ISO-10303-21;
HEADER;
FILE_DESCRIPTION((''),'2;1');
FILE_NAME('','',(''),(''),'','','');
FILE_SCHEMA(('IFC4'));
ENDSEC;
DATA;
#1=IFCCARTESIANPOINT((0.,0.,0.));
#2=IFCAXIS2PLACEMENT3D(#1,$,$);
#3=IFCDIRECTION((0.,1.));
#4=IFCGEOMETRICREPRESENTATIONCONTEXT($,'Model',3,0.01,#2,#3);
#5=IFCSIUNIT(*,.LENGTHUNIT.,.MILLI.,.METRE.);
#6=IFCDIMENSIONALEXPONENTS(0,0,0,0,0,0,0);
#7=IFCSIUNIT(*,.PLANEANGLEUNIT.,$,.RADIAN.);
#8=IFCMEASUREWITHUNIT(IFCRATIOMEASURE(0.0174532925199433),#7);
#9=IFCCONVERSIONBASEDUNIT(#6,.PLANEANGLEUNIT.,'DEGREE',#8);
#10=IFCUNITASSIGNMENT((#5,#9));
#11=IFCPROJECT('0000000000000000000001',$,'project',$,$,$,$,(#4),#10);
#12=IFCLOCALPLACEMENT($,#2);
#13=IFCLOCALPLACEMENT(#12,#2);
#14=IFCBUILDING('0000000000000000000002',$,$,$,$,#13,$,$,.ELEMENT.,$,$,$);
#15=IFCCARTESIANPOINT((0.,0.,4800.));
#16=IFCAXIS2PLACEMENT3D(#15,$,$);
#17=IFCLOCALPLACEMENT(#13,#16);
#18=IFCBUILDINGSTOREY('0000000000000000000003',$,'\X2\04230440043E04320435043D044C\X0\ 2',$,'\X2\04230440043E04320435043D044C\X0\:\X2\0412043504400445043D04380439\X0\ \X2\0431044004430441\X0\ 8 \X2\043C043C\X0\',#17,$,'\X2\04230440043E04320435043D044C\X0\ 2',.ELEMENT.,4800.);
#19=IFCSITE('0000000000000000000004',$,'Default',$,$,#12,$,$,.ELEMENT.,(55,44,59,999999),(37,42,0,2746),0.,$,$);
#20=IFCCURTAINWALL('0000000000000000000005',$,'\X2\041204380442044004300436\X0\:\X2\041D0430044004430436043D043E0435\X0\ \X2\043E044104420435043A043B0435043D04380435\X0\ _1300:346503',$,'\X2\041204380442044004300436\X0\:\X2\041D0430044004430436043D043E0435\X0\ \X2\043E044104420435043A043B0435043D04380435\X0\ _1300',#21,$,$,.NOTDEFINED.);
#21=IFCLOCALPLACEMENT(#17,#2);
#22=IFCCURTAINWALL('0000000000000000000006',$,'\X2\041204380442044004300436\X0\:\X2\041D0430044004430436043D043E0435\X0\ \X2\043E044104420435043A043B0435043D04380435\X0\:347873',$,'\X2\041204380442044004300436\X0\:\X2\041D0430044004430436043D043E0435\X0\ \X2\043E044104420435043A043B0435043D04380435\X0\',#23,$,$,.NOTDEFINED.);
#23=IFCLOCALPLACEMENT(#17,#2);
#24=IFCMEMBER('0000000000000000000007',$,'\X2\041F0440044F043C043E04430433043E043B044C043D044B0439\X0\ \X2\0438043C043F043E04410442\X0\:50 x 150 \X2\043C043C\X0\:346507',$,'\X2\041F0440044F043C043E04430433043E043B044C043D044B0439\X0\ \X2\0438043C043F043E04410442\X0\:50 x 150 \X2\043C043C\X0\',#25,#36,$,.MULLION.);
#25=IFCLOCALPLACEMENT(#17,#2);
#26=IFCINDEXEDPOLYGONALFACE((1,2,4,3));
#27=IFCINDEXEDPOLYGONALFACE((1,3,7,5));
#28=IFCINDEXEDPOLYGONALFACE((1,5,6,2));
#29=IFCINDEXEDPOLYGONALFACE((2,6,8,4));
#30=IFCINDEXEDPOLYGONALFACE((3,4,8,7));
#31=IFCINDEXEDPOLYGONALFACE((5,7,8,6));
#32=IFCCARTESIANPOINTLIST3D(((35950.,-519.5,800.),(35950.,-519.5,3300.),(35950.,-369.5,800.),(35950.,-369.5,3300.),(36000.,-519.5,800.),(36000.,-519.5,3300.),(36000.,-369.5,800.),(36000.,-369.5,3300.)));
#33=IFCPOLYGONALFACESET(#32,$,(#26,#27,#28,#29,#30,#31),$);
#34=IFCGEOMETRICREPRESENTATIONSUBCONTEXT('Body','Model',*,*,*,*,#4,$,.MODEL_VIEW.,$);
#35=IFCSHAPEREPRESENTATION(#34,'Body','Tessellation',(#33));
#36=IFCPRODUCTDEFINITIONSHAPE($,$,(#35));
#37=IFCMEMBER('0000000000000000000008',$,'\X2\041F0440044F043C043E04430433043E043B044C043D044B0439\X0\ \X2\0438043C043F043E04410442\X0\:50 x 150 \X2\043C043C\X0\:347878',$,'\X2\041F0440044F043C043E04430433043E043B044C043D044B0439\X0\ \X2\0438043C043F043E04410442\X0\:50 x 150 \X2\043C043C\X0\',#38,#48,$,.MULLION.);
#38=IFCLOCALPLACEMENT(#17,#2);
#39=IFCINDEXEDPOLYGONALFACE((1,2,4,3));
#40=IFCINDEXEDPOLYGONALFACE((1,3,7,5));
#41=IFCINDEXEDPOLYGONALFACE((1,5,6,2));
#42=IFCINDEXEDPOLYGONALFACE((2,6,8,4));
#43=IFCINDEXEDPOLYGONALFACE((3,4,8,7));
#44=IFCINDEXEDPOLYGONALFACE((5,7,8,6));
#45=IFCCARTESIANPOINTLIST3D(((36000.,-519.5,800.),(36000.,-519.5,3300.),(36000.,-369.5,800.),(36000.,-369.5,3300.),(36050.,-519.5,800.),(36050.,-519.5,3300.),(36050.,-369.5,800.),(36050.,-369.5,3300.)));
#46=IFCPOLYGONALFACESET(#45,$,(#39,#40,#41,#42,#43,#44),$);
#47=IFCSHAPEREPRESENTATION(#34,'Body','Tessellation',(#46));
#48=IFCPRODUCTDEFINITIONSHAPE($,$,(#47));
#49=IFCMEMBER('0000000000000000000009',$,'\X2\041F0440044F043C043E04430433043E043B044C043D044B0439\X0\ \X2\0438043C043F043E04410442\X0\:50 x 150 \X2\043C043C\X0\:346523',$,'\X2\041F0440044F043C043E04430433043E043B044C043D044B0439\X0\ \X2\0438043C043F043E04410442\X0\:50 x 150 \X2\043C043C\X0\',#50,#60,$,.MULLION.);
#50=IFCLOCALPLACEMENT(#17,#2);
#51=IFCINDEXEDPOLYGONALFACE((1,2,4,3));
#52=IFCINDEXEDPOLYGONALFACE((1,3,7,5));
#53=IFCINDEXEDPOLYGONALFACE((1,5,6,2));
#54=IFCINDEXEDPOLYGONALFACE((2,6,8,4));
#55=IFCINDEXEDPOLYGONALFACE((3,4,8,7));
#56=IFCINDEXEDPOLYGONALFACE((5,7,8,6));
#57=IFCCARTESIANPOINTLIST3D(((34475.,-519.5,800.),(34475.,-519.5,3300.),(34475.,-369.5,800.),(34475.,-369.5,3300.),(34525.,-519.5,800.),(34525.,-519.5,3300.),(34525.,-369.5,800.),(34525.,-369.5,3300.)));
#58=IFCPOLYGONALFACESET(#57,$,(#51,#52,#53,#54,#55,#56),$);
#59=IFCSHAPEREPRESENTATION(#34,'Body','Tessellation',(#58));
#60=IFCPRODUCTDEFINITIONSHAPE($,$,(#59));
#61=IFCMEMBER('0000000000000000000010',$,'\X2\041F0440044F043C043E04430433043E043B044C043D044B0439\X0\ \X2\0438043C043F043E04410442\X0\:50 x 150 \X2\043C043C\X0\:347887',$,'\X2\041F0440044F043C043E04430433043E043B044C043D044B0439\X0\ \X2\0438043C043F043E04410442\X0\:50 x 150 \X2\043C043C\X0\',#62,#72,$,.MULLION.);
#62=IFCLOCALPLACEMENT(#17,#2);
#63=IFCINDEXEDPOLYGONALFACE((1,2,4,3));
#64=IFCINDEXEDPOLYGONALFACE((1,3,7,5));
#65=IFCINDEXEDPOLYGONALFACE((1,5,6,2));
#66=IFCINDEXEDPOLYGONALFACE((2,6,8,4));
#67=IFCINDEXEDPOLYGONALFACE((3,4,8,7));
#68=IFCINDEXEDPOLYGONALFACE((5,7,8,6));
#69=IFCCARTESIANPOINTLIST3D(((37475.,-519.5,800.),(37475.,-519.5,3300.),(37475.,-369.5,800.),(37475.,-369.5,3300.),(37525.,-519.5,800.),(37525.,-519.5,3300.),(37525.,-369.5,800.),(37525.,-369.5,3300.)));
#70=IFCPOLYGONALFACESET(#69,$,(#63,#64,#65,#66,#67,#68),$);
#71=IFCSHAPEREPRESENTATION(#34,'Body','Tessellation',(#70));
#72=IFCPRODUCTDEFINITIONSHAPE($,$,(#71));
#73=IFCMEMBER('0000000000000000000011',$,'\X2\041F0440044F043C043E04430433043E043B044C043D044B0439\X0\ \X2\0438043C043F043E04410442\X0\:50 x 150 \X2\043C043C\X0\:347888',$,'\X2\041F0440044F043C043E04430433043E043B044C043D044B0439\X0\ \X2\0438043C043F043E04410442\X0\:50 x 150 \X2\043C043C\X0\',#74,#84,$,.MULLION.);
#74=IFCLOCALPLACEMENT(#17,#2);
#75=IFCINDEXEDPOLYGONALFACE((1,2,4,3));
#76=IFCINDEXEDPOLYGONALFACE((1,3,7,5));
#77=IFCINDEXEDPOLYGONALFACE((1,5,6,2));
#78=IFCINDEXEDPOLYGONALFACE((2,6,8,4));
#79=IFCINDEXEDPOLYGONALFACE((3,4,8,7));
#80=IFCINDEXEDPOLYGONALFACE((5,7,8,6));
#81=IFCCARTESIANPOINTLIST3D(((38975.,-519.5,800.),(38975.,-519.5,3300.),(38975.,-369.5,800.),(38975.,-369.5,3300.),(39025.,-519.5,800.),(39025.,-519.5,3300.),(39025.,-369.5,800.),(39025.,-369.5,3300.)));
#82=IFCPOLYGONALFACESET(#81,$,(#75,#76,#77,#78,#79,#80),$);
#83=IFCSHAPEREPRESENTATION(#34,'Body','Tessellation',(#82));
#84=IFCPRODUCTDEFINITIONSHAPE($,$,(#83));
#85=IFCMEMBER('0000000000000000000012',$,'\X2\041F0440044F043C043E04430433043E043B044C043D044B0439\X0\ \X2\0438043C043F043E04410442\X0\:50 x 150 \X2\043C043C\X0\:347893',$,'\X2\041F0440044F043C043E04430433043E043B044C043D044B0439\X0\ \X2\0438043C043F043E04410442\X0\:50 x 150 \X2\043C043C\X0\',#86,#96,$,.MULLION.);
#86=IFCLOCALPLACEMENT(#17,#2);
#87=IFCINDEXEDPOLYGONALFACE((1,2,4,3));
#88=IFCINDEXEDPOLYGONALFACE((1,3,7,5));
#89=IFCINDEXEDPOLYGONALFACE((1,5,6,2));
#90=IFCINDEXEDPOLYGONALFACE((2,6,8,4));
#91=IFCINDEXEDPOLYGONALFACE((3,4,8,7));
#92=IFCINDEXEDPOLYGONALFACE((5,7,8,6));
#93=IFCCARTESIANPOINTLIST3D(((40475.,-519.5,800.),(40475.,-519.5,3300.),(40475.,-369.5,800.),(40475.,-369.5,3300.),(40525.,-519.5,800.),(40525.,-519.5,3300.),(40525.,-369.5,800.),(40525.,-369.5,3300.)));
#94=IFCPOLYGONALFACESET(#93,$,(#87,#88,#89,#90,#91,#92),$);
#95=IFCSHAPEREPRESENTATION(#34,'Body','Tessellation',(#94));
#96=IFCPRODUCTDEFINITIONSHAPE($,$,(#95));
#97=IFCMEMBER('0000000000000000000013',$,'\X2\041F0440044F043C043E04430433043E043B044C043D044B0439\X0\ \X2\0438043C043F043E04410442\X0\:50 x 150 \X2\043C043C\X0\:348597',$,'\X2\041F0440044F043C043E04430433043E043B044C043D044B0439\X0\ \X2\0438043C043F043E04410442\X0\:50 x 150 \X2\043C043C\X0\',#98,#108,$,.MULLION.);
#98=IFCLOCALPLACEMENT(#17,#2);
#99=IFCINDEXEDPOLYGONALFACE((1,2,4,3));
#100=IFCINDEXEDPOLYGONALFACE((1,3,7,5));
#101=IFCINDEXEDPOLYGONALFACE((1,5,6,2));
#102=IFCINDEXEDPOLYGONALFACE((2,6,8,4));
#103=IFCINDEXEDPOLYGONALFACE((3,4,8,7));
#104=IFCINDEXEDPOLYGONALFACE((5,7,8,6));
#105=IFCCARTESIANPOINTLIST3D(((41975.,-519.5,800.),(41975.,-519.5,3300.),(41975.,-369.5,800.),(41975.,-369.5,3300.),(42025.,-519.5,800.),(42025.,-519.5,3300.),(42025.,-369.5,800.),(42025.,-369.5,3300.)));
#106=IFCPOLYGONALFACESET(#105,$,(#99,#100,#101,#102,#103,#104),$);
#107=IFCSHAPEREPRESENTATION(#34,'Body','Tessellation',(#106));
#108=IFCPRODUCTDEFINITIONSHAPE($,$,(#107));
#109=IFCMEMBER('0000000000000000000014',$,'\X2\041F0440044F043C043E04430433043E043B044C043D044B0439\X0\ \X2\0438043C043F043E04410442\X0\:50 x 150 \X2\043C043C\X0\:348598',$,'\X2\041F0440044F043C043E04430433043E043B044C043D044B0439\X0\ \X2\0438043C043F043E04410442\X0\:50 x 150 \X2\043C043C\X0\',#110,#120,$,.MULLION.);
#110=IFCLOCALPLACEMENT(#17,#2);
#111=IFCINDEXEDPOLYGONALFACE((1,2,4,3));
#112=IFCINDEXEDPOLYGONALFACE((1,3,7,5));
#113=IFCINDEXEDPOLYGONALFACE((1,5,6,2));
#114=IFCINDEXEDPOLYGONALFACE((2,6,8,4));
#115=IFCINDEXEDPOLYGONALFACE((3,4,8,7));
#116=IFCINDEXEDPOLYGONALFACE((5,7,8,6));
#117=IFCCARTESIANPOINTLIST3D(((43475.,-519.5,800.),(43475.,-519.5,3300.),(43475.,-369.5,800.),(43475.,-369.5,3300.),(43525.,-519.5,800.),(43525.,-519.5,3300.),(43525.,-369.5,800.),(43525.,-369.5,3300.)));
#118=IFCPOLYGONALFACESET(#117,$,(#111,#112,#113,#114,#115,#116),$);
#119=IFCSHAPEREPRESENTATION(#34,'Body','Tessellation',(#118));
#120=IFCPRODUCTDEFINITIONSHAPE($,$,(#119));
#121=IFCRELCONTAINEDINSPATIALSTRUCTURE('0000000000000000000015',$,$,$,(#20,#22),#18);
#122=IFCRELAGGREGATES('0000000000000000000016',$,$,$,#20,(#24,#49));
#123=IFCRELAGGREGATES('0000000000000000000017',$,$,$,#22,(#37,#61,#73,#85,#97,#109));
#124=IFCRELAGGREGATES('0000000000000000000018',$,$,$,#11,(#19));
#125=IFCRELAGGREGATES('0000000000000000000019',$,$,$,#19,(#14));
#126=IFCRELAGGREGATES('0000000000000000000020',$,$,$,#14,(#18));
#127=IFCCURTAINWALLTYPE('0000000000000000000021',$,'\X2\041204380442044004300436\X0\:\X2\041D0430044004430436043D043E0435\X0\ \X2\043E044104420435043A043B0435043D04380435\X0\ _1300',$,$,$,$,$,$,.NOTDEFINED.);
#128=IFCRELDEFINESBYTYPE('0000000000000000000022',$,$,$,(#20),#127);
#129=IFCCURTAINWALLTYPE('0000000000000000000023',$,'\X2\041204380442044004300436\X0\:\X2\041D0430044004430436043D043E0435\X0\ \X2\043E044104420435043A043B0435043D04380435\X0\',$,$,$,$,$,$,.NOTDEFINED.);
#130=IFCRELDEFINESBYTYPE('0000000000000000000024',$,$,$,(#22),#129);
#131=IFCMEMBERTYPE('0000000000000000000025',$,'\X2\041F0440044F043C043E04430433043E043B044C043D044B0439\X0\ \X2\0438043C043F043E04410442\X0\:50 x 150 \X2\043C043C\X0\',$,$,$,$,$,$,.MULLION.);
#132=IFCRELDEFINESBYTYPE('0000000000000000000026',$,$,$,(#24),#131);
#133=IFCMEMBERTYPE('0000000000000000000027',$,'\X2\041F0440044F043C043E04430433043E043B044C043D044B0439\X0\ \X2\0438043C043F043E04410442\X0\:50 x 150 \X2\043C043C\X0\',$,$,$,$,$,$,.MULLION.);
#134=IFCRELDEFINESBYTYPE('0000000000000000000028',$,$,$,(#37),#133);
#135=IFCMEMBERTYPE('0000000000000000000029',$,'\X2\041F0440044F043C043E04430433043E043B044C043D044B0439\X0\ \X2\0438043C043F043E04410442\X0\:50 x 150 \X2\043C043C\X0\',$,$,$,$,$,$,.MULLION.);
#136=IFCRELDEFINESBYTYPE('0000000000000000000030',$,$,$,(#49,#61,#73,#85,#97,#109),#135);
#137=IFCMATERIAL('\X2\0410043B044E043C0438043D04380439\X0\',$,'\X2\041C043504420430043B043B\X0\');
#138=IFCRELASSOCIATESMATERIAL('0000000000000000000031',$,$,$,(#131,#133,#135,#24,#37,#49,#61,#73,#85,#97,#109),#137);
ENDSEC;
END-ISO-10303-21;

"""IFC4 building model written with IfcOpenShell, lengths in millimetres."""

from ifc_helpers import new_model, entity, si_unit, converted_unit, direction, frame, origin, origin_2d_with_axis, place, context, subcontext, project, spatial, rectangle, extrude, source, transform, mapped, material, material_profile, profile_set, profile_usage, type_object, type_shapes, element, aggregate, save


model = new_model("IFC4")

# Units and contexts
model_context = context("Model", 3, precision=0.01, world=origin(), true_north=direction((0.0, 1.0)))
body_context = subcontext(model_context, "Body", "Model", "MODEL_VIEW")
ifc_project = project(units=[si_unit("LENGTHUNIT", "METRE", prefix="MILLI"), converted_unit("PLANEANGLEUNIT", "DEGREE", entity("IfcRatioMeasure", 0.0174532925199433), si_unit("PLANEANGLEUNIT", "RADIAN"), dimensions=[0, 0, 0, 0, 0, 0, 0])], contexts=[model_context])

# Site, building, storey
site_placement = place(None, origin())
site = spatial("IfcSite", under=ifc_project, at=site_placement, Name="Default", CompositionType="ELEMENT", RefLatitude=(55, 44, 59, 999999), RefLongitude=(37, 42, 0, 2746), RefElevation=0.0)
building_placement = place(site_placement, origin())
building = spatial("IfcBuilding", under=site, at=building_placement, CompositionType="ELEMENT")
storey_placement = place(building_placement, frame((0.0, 0.0, 4800.0)))
storey = spatial("IfcBuildingStorey", under=building, at=storey_placement, Name="Уровень 2", ObjectType="Уровень:Верхний брус 8 мм", LongName="Уровень 2", CompositionType="ELEMENT", Elevation=4800.0)

# Curtain wall
curtain_wall_type_1 = type_object("IfcCurtainWallType", Name="Витраж:Наружное остекление _1300", PredefinedType="NOTDEFINED")
curtain_wall_1_placement = place(storey_placement, frame((0.0, 0.0, -4800.0)))
curtain_wall_1 = element("IfcCurtainWall", 1, at=curtain_wall_1_placement, inside=storey, type_object=curtain_wall_type_1, Name="Витраж:Наружное остекление _1300:346503", ObjectType="Витраж:Наружное остекление _1300", PredefinedType="NOTDEFINED")
ifc_material = material(Name="Алюминий", Category="Металл")
ifc_material_profile = material_profile(ifc_material, rectangle(XDim=150.0, YDim=50.0, at=origin_2d_with_axis()), Name="50 x 150 мм")
ifc_profile_set = profile_set([ifc_material_profile], Name="50 x 150 мм")

# Curtain wall
curtain_wall_type_2 = type_object("IfcCurtainWallType", Name="Витраж:Наружное остекление", PredefinedType="NOTDEFINED")
curtain_wall_2_placement = place(storey_placement, frame((0.0, 0.0, -4800.0)))
curtain_wall_2 = element("IfcCurtainWall", 2, at=curtain_wall_2_placement, inside=storey, type_object=curtain_wall_type_2, Name="Витраж:Наружное остекление:347873", ObjectType="Витраж:Наружное остекление", PredefinedType="NOTDEFINED")

# Members
ifc_profile_usage_1 = profile_usage(ifc_profile_set)
member_type_1 = type_object("IfcMemberType", Name="Прямоугольный импост:50 x 150 мм", PredefinedType="MULLION", material=ifc_profile_set)
shared_shape_1 = source(origin(), body_context, "Body", "SweptSolid", [
    extrude(rectangle(XDim=150.0, YDim=50.0, at=origin_2d_with_axis()), frame((-25.0, 0.0, -2500.0), z_axis=(0.0, 0.0, 1.0), x_axis=(0.0, -1.0, 0.0)), (0.0, 0.0, 1.0), 2500.0),
])
type_shapes(member_type_1, [shared_shape_1])
member_1_placement = place(storey_placement, frame((36000.0, -444.5, 800.0), z_axis=(0.0, 0.0, -1.0), x_axis=(1.0, 0.0, 0.0)))
member_1 = element("IfcMember", 3, at=member_1_placement, type_object=member_type_1, material=ifc_profile_usage_1, Name="Прямоугольный импост:50 x 150 мм:346507", ObjectType="Прямоугольный импост:50 x 150 мм", PredefinedType="MULLION", context=body_context, shape_type="MappedRepresentation", body=[
    mapped(shared_shape_1, transform((0.0, 0.0, 0.0), scale=1.0)),
])
ifc_profile_usage_2 = profile_usage(ifc_profile_set)
member_type_2 = type_object("IfcMemberType", Name="Прямоугольный импост:50 x 150 мм", PredefinedType="MULLION", material=ifc_profile_set)
shared_shape_2 = source(origin(), body_context, "Body", "SweptSolid", [
    extrude(rectangle(XDim=150.0, YDim=50.0, at=origin_2d_with_axis()), frame((-25.0, 0.0, -2500.0), z_axis=(0.0, 0.0, 1.0), x_axis=(0.0, -1.0, 0.0)), (0.0, 0.0, 1.0), 2500.0),
])
type_shapes(member_type_2, [shared_shape_2])
member_2_placement = place(storey_placement, frame((36000.0, -444.5, 3300.0), z_axis=(0.0, 0.0, 1.0), x_axis=(-1.0, 0.0, 0.0)))
member_2 = element("IfcMember", 4, at=member_2_placement, type_object=member_type_2, material=ifc_profile_usage_2, Name="Прямоугольный импост:50 x 150 мм:347878", ObjectType="Прямоугольный импост:50 x 150 мм", PredefinedType="MULLION", context=body_context, shape_type="MappedRepresentation", body=[
    mapped(shared_shape_2, transform((0.0, 0.0, 0.0), scale=1.0)),
])
ifc_profile_usage_3 = profile_usage(ifc_profile_set)
member_type_3 = type_object("IfcMemberType", Name="Прямоугольный импост:50 x 150 мм", PredefinedType="MULLION", material=ifc_profile_set)
shared_shape_3 = source(origin(), body_context, "Body", "SweptSolid", [
    extrude(rectangle(XDim=150.0, YDim=50.0, at=origin_2d_with_axis()), frame((0.0, 0.0, -2500.0), z_axis=(0.0, 0.0, 1.0), x_axis=(0.0, -1.0, 0.0)), (0.0, 0.0, 1.0), 2500.0),
])
type_shapes(member_type_3, [shared_shape_3])
member_3_placement = place(storey_placement, frame((34500.0, -444.5, 800.0), z_axis=(0.0, 0.0, -1.0), x_axis=(1.0, 0.0, 0.0)))
member_3 = element("IfcMember", 5, at=member_3_placement, type_object=member_type_3, material=ifc_profile_usage_3, Name="Прямоугольный импост:50 x 150 мм:346523", ObjectType="Прямоугольный импост:50 x 150 мм", PredefinedType="MULLION", context=body_context, shape_type="MappedRepresentation", body=[
    mapped(shared_shape_3, transform((0.0, 0.0, 0.0), scale=1.0)),
])
aggregate(curtain_wall_1, [member_1, member_3])
ifc_profile_usage_4 = profile_usage(ifc_profile_set)
member_4_placement = place(storey_placement, frame((37500.0, -444.5, 800.0), z_axis=(0.0, 0.0, -1.0), x_axis=(1.0, 0.0, 0.0)))
member_4 = element("IfcMember", 6, at=member_4_placement, type_object=member_type_3, material=ifc_profile_usage_4, Name="Прямоугольный импост:50 x 150 мм:347887", ObjectType="Прямоугольный импост:50 x 150 мм", PredefinedType="MULLION", context=body_context, shape_type="MappedRepresentation", body=[
    mapped(shared_shape_3, transform((0.0, 0.0, 0.0), scale=1.0)),
])
ifc_profile_usage_5 = profile_usage(ifc_profile_set)
member_5_placement = place(storey_placement, frame((39000.0, -444.5, 800.0), z_axis=(0.0, 0.0, -1.0), x_axis=(1.0, 0.0, 0.0)))
member_5 = element("IfcMember", 7, at=member_5_placement, type_object=member_type_3, material=ifc_profile_usage_5, Name="Прямоугольный импост:50 x 150 мм:347888", ObjectType="Прямоугольный импост:50 x 150 мм", PredefinedType="MULLION", context=body_context, shape_type="MappedRepresentation", body=[
    mapped(shared_shape_3, transform((0.0, 0.0, 0.0), scale=1.0)),
])
ifc_profile_usage_6 = profile_usage(ifc_profile_set)
member_6_placement = place(storey_placement, frame((40500.0, -444.5, 800.0), z_axis=(0.0, 0.0, -1.0), x_axis=(1.0, 0.0, 0.0)))
member_6 = element("IfcMember", 8, at=member_6_placement, type_object=member_type_3, material=ifc_profile_usage_6, Name="Прямоугольный импост:50 x 150 мм:347893", ObjectType="Прямоугольный импост:50 x 150 мм", PredefinedType="MULLION", context=body_context, shape_type="MappedRepresentation", body=[
    mapped(shared_shape_3, transform((0.0, 0.0, 0.0), scale=1.0)),
])
ifc_profile_usage_7 = profile_usage(ifc_profile_set)
member_7_placement = place(storey_placement, frame((42000.0, -444.5, 800.0), z_axis=(0.0, 0.0, -1.0), x_axis=(1.0, 0.0, 0.0)))
member_7 = element("IfcMember", 9, at=member_7_placement, type_object=member_type_3, material=ifc_profile_usage_7, Name="Прямоугольный импост:50 x 150 мм:348597", ObjectType="Прямоугольный импост:50 x 150 мм", PredefinedType="MULLION", context=body_context, shape_type="MappedRepresentation", body=[
    mapped(shared_shape_3, transform((0.0, 0.0, 0.0), scale=1.0)),
])
ifc_profile_usage_8 = profile_usage(ifc_profile_set)
member_8_placement = place(storey_placement, frame((43500.0, -444.5, 800.0), z_axis=(0.0, 0.0, -1.0), x_axis=(1.0, 0.0, 0.0)))
member_8 = element("IfcMember", 10, at=member_8_placement, type_object=member_type_3, material=ifc_profile_usage_8, Name="Прямоугольный импост:50 x 150 мм:348598", ObjectType="Прямоугольный импост:50 x 150 мм", PredefinedType="MULLION", context=body_context, shape_type="MappedRepresentation", body=[
    mapped(shared_shape_3, transform((0.0, 0.0, 0.0), scale=1.0)),
])
aggregate(curtain_wall_2, [member_2, member_4, member_5, member_6, member_7, member_8])

save(model, "model.ifc")
